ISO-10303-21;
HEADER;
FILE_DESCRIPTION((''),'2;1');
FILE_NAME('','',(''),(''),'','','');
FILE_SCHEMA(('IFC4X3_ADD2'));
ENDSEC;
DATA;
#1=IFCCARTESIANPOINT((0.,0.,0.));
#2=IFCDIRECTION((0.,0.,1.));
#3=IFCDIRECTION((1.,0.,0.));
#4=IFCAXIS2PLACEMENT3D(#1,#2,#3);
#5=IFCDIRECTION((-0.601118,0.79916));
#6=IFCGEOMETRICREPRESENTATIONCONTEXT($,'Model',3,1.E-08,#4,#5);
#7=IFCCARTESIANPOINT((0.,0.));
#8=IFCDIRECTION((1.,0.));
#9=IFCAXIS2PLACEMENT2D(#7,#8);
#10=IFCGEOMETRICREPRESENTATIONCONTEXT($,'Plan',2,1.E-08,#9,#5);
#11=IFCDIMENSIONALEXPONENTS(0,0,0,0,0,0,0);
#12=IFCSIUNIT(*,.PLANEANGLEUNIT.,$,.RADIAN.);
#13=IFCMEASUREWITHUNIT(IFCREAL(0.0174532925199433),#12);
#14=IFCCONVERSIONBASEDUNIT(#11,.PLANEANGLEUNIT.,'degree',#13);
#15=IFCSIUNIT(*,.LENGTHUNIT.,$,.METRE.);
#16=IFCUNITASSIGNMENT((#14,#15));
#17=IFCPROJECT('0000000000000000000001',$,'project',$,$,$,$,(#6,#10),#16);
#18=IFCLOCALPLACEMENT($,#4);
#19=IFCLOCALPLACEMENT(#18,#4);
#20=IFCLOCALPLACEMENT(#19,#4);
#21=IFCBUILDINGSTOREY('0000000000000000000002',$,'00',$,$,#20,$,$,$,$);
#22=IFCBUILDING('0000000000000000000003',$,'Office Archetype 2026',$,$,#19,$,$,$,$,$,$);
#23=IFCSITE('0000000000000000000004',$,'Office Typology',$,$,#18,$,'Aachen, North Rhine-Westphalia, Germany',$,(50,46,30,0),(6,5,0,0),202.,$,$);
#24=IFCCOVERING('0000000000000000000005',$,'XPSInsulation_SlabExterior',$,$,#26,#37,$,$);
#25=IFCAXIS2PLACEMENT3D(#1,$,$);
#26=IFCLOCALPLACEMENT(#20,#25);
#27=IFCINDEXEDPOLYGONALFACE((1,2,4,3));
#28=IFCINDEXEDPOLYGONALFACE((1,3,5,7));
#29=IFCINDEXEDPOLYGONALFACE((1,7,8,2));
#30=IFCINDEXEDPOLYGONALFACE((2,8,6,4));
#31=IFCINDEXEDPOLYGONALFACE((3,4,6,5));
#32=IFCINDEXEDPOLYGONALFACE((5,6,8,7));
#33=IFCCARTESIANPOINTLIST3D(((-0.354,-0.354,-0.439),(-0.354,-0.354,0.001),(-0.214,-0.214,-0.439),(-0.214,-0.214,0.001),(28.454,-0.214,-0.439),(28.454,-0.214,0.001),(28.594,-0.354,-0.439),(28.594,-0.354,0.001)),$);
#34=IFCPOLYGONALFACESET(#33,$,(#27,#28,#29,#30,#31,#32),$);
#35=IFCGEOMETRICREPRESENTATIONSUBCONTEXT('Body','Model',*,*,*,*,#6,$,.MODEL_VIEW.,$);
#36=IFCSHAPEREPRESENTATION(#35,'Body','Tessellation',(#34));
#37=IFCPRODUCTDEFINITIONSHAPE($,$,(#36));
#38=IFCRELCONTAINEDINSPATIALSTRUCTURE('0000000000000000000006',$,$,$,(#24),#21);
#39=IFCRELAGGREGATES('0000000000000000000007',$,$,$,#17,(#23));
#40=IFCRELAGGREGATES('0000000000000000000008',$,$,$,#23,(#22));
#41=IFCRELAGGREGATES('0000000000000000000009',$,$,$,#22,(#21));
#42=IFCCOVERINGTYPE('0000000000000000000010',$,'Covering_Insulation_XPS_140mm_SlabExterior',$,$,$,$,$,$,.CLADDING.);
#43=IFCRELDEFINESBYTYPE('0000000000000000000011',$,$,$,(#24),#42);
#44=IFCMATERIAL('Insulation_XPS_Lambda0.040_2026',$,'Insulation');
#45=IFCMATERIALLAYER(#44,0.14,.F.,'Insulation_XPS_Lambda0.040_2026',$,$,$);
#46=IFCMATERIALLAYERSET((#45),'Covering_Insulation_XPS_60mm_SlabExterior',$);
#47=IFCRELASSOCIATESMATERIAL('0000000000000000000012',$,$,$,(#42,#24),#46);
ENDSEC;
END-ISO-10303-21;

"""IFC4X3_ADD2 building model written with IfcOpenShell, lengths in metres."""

from ifc_helpers import new_model, entity, si_unit, converted_unit, direction, frame, origin_with_axes, origin_2d_with_axis, place, context, subcontext, project, spatial, line, indexed_curve, outline, extrude, material, layer, layer_set, layer_usage, type_object, element, save


model = new_model("IFC4X3_ADD2")

# Units and contexts
model_context = context("Model", 3, precision=1e-08, world=origin_with_axes(), true_north=direction((-0.601118, 0.79916)))
plan_context = context("Plan", 2, precision=1e-08, world=origin_2d_with_axis(), true_north=direction((-0.601118, 0.79916)))
body_context = subcontext(model_context, "Body", "Model", "MODEL_VIEW")
ifc_project = project(units=[converted_unit("PLANEANGLEUNIT", "degree", entity("IfcReal", 0.0174532925199433), si_unit("PLANEANGLEUNIT", "RADIAN"), dimensions=[0, 0, 0, 0, 0, 0, 0]), si_unit("LENGTHUNIT", "METRE")], contexts=[model_context, plan_context])

# Site, building, storey
site_placement = place(None, origin_with_axes())
site = spatial("IfcSite", under=ifc_project, at=site_placement, Name="Office Typology", LongName="Aachen, North Rhine-Westphalia, Germany", RefLatitude=(50, 46, 30, 0), RefLongitude=(6, 5, 0, 0), RefElevation=202.0)
building_placement = place(site_placement, origin_with_axes())
building = spatial("IfcBuilding", under=site, at=building_placement, Name="Office Archetype 2026")
storey_placement = place(building_placement, origin_with_axes())
storey = spatial("IfcBuildingStorey", under=building, at=storey_placement, Name="00")

# Shared definitions
ifc_material_1 = material(Name="Insulation_XPS_Lambda0.040_2026", Category="Insulation")

# Covering
ifc_layer_1 = layer(ifc_material_1, 0.14, ventilated=False, Name="Insulation_XPS_Lambda0.040_2026")
ifc_layer_set_1 = layer_set([ifc_layer_1], Name="Covering_Insulation_XPS_60mm_SlabExterior")
ifc_layer_usage_1 = layer_usage(ifc_layer_set_1, "AXIS2", "POSITIVE", 0.0)
covering_type_1 = type_object("IfcCoveringType", Name="Covering_Insulation_XPS_140mm_SlabExterior", PredefinedType="CLADDING", material=ifc_layer_set_1)
covering_1_placement = place(storey_placement, frame((-0.354, -0.354, -0.439), z_axis=(0.0, 0.0, 1.0), x_axis=(1.0, 0.0, 0.0)))
element("IfcCovering", 1, at=covering_1_placement, inside=storey, type_object=covering_type_1, material=ifc_layer_usage_1, Name="XPSInsulation_SlabExterior", context=body_context, shape_type="SweptSolid", body=[
    extrude(outline(indexed_curve([(0.0, 0.0), (0.14, 0.14), (28.808, 0.14), (28.948, 0.0)], segments=[line(1, 2, 3, 4, 1)])), origin_with_axes(), (0.0, 0.0, 1.0), 0.44),
])

save(model, "model.ifc")
